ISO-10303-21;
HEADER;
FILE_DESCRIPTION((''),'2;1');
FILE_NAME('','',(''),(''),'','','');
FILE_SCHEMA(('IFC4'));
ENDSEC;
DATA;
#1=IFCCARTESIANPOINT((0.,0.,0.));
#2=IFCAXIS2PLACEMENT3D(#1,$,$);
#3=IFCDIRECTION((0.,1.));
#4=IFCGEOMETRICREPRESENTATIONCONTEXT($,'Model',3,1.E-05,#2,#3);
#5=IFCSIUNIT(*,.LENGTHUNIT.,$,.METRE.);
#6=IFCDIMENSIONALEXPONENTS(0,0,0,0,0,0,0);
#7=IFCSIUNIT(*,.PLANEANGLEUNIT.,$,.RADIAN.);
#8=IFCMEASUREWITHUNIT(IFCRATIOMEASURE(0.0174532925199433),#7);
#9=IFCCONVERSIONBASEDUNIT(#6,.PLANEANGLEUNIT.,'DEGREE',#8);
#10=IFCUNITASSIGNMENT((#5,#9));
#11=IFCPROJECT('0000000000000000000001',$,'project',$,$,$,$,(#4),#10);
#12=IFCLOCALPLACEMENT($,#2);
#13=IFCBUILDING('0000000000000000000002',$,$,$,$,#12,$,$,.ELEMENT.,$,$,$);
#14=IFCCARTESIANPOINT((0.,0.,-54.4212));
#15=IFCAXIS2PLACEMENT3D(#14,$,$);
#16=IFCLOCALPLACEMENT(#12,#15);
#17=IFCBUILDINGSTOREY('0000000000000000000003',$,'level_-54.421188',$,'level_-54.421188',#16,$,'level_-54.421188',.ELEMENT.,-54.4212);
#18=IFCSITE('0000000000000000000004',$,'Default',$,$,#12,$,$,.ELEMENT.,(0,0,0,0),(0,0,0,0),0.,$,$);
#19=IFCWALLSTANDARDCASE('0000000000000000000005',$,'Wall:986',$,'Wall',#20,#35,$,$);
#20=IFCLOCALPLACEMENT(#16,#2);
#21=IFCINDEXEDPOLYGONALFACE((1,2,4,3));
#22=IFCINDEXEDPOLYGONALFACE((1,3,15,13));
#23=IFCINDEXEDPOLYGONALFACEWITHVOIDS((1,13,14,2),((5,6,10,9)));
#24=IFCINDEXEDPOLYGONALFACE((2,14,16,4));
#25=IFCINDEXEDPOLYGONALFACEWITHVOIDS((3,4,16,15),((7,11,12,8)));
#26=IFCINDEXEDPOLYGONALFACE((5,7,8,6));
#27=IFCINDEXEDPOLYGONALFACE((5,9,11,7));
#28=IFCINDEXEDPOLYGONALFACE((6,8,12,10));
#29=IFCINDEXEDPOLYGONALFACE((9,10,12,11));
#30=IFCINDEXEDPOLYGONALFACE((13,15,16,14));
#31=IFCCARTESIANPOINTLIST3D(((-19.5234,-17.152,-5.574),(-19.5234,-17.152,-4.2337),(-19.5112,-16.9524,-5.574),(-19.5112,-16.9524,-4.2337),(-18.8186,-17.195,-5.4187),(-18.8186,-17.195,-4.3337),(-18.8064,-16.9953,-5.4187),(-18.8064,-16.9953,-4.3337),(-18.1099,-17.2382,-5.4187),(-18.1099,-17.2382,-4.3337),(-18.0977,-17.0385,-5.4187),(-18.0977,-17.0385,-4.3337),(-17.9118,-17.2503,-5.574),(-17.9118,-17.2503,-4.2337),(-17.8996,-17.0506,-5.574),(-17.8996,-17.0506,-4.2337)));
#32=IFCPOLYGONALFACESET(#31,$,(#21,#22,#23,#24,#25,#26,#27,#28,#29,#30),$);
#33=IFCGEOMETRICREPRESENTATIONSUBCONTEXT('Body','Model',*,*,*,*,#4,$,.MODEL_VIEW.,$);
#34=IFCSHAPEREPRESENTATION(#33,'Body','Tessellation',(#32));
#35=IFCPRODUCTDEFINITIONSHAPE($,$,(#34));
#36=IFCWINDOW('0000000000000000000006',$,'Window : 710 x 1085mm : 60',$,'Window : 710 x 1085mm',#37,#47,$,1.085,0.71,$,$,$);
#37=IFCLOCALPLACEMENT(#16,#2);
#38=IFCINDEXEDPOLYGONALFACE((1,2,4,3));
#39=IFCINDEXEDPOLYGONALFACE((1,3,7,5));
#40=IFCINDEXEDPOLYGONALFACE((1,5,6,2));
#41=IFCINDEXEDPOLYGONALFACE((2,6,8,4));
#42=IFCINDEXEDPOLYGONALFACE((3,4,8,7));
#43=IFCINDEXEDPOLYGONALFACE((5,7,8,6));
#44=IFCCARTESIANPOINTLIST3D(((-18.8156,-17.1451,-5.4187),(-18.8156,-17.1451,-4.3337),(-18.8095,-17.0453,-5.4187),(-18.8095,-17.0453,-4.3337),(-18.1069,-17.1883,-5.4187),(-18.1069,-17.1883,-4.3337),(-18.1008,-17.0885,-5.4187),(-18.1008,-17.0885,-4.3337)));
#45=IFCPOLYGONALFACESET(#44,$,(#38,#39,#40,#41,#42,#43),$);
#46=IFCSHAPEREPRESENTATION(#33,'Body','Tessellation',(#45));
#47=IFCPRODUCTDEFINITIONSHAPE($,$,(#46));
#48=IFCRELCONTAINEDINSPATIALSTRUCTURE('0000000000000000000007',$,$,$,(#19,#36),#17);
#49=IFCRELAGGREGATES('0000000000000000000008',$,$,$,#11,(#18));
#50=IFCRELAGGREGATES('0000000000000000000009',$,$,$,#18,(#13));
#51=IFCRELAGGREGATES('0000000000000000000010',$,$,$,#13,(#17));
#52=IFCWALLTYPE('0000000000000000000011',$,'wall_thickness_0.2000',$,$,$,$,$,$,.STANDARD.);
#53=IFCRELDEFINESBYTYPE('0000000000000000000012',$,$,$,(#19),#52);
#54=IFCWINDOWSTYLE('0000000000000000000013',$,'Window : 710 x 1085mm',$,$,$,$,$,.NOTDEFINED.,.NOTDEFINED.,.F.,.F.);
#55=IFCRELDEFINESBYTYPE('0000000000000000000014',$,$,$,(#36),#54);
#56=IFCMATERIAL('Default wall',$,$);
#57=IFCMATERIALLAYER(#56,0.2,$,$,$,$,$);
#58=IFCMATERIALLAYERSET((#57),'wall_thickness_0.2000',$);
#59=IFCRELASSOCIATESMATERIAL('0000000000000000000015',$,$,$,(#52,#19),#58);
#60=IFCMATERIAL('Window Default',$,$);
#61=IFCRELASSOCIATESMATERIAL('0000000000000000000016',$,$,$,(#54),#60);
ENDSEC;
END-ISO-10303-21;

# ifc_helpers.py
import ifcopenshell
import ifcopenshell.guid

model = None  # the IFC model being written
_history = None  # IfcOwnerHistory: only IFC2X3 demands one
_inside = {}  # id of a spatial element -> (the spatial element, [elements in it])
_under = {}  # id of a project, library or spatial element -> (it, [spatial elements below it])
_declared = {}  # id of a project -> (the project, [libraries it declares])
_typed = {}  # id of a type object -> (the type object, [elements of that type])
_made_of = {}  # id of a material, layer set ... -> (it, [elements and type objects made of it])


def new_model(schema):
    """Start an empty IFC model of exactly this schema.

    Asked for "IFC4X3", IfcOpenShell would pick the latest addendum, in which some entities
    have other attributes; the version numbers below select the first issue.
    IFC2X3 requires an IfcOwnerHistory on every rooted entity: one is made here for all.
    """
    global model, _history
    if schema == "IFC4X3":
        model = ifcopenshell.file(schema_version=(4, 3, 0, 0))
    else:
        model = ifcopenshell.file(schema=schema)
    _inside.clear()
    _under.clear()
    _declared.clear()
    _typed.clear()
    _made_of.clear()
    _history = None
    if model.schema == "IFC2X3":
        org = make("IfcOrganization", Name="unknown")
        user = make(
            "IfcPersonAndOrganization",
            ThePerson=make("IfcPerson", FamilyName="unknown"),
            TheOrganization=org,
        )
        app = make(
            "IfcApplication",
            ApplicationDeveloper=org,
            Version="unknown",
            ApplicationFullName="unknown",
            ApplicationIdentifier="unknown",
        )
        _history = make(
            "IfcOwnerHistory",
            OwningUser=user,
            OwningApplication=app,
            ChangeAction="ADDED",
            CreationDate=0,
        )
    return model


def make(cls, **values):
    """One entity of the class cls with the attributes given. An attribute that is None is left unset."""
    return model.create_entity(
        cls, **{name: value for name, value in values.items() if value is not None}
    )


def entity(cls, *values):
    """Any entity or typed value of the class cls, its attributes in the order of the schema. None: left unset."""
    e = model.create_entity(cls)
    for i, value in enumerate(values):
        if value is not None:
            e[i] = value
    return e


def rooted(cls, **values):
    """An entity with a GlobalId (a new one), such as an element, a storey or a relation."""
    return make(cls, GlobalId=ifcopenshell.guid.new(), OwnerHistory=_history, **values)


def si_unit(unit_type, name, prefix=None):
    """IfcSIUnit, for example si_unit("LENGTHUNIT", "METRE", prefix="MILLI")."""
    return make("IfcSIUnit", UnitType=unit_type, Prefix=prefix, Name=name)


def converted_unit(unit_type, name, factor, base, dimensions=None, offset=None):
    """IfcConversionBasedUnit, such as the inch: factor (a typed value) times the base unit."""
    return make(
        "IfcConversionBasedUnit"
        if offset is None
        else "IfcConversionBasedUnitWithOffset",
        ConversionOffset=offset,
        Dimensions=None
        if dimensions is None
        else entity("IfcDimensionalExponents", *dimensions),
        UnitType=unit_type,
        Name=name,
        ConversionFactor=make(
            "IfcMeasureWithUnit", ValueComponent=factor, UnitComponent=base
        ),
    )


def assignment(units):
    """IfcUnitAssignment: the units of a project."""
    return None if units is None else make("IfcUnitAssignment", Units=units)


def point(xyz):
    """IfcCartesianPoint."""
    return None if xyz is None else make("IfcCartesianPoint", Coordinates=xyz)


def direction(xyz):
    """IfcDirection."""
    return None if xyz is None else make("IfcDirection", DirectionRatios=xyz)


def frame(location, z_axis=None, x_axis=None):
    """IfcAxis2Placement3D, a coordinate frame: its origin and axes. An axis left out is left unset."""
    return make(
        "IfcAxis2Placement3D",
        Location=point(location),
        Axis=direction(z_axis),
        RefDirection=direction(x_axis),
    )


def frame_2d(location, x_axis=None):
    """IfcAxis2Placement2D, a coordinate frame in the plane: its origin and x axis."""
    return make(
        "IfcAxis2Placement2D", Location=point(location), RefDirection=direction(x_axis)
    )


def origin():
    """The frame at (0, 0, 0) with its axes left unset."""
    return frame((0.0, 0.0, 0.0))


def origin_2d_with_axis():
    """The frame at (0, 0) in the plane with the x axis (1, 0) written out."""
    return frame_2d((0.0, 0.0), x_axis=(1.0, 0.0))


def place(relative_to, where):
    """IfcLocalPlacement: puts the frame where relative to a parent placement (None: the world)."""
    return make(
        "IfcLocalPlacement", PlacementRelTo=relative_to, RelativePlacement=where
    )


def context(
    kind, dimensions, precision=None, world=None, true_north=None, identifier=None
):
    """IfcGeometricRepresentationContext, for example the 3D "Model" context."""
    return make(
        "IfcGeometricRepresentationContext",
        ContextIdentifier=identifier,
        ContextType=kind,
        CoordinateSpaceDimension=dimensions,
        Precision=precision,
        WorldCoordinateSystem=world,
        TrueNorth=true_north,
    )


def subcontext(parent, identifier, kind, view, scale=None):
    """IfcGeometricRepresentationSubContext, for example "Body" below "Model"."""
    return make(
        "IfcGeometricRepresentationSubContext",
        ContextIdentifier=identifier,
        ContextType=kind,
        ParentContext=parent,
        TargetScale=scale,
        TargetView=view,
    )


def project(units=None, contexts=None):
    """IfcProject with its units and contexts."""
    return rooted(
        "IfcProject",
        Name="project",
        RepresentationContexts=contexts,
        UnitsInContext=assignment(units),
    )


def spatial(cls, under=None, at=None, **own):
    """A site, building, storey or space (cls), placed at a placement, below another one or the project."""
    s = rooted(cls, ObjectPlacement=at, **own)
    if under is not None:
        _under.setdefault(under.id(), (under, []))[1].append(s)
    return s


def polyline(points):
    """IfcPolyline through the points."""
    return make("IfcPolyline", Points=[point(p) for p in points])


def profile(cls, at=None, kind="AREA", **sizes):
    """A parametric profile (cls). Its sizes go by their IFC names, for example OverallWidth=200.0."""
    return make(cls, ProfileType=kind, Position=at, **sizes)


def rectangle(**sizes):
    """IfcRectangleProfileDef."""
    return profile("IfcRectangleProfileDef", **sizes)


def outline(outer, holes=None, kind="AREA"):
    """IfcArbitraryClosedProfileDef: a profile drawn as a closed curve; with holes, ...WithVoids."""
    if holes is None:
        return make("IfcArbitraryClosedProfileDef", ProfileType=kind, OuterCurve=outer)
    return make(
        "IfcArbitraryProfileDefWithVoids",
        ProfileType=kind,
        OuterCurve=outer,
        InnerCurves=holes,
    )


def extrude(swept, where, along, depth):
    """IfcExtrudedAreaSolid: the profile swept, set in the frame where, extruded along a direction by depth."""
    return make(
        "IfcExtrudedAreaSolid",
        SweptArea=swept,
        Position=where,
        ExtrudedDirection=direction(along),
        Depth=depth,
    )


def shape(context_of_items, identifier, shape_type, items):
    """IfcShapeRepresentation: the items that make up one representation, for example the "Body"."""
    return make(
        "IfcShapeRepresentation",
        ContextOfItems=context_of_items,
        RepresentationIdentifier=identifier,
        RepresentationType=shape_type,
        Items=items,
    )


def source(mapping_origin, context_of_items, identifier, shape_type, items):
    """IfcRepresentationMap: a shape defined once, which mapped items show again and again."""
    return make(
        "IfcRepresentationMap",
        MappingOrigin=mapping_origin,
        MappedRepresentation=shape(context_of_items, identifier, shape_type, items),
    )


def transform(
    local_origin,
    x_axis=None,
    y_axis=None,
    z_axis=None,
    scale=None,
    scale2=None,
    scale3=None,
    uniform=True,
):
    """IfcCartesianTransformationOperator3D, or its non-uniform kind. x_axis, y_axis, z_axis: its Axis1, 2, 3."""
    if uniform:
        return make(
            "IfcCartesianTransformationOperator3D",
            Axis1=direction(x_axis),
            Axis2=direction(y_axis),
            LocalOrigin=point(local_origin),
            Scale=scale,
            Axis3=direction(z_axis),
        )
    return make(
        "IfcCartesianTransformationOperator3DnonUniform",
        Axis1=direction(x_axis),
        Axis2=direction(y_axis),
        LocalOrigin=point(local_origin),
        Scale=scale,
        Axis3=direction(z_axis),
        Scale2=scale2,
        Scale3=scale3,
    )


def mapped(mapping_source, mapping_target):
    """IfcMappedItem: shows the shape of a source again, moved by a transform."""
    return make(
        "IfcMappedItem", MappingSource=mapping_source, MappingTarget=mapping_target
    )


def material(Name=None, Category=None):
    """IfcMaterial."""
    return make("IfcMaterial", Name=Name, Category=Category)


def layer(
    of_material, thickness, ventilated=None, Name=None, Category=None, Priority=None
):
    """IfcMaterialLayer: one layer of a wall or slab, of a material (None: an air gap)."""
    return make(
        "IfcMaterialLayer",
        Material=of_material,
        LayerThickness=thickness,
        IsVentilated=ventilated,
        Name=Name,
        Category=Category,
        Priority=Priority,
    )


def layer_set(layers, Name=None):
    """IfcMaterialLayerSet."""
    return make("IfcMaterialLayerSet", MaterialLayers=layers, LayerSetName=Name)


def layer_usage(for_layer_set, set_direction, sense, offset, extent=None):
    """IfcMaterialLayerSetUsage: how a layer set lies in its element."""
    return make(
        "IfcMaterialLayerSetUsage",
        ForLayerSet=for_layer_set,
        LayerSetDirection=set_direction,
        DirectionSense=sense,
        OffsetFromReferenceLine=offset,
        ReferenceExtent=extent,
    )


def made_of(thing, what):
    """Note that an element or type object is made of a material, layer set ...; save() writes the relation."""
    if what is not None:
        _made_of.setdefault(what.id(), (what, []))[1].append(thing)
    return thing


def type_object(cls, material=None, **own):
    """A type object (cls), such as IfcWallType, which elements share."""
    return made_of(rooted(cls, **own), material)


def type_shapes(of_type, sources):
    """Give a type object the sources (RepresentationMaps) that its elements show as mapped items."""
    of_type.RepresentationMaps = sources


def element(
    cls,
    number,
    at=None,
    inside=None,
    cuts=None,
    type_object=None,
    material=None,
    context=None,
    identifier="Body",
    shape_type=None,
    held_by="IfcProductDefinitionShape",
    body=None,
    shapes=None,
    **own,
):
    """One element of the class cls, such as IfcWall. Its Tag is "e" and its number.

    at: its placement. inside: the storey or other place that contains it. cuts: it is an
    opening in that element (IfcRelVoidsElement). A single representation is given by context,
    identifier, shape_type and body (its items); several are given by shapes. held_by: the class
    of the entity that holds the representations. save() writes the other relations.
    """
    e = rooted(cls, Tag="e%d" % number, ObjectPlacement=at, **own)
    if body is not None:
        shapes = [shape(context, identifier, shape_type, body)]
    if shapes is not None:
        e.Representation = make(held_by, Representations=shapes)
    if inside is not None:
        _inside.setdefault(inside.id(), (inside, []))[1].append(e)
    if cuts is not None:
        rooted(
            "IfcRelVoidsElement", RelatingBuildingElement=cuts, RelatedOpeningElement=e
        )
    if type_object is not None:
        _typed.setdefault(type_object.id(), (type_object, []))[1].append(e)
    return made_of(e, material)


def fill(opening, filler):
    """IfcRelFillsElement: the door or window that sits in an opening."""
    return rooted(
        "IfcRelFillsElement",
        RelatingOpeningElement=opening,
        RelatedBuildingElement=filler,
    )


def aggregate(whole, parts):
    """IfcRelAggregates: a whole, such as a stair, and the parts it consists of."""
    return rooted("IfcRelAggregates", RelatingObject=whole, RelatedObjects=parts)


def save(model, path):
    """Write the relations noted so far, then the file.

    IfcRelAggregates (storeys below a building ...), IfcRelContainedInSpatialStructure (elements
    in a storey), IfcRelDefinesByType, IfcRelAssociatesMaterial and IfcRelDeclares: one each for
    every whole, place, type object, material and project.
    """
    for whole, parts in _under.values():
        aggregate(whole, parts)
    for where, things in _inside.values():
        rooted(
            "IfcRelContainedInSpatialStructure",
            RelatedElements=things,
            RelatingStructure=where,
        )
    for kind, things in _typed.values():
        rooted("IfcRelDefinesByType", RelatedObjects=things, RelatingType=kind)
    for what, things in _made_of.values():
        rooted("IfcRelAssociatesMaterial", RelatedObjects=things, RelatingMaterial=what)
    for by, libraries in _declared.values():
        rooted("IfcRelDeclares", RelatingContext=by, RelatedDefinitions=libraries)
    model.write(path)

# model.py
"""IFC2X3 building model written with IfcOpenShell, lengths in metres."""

from ifc_helpers import new_model, entity, si_unit, converted_unit, direction, frame, frame_2d, origin, origin_2d_with_axis, place, context, subcontext, project, spatial, polyline, rectangle, outline, extrude, source, transform, mapped, material, layer, layer_set, layer_usage, type_object, type_shapes, element, fill, save


model = new_model("IFC2X3")

# Units and contexts
model_context = context("Model", 3, precision=1e-05, world=origin(), true_north=direction((0.0, 1.0)))
body_context = subcontext(model_context, "Body", "Model", "MODEL_VIEW")
ifc_project = project(units=[si_unit("LENGTHUNIT", "METRE"), converted_unit("PLANEANGLEUNIT", "DEGREE", entity("IfcRatioMeasure", 0.0174532925199433), si_unit("PLANEANGLEUNIT", "RADIAN"), dimensions=[0, 0, 0, 0, 0, 0, 0])], contexts=[model_context])

# Site, building, storey
placement_1 = place(None, origin())
site = spatial("IfcSite", under=ifc_project, at=placement_1, Name="Default", CompositionType="ELEMENT", RefLatitude=(0, 0, 0, 0), RefLongitude=(0, 0, 0, 0), RefElevation=0.0)
building = spatial("IfcBuilding", under=site, at=placement_1, CompositionType="ELEMENT")
storey_placement = place(placement_1, frame((0.0, 0.0, -54.4212)))
storey = spatial("IfcBuildingStorey", under=building, at=storey_placement, Name="level_-54.421188", ObjectType="level_-54.421188", LongName="level_-54.421188", CompositionType="ELEMENT", Elevation=-54.4212)

# Wall, opening, window
ifc_material_1 = material(Name="Default wall")
ifc_layer = layer(ifc_material_1, 0.2)
ifc_layer_set = layer_set([ifc_layer], Name="wall_thickness_0.2000")
ifc_layer_usage = layer_usage(ifc_layer_set, "AXIS2", "POSITIVE", -0.1)
wall_type = type_object("IfcWallType", Name="wall_thickness_0.2000", PredefinedType="STANDARD", material=ifc_layer_set)
placement_2 = place(placement_1, frame((0.0, 0.0, -59.9952)))
wall_1_placement = place(placement_2, frame((-17.9057, -17.1504, 0.0), z_axis=(0.0, 0.0, 1.0), x_axis=(-0.998147, 0.060844, 0.0)))
wall_1 = element("IfcWallStandardCase", 1, at=wall_1_placement, inside=storey, type_object=wall_type, material=ifc_layer_usage, Name="Wall:986", ObjectType="Wall", context=body_context, shape_type="SweptSolid", body=[
    extrude(outline(polyline([(1.6146, -0.1), (1.6146, 0.1), (0.0, 0.1), (0.0, -0.1), (1.6146, -0.1)])), origin(), (0.0, 0.0, 1.0), 1.3402),
])
opening_1_placement = place(wall_1_placement, frame((0.1985, -0.1, 0.1553)))
opening_1 = element("IfcOpeningElement", 2, at=opening_1_placement, cuts=wall_1, ObjectType="Opening", context=body_context, shape_type="SweptSolid", body=[
    extrude(rectangle(XDim=0.71, YDim=1.085, at=frame_2d((0.5425, 0.355), x_axis=(0.0, 1.0))), frame((0.0, 0.0, 0.0), z_axis=(0.0, 1.0, 0.0), x_axis=(0.0, 0.0, 1.0)), (0.0, 0.0, 1.0), 0.2),
])
ifc_material_2 = material(Name="Window Default")
window_style_1 = type_object("IfcWindowStyle", Name="Window : 710 x 1085mm", ConstructionType="NOTDEFINED", OperationType="NOTDEFINED", ParameterTakesPrecedence=False, Sizeable=False, material=ifc_material_2)
shared_shape_1 = source(origin(), body_context, "Body", "SweptSolid", [
    extrude(rectangle(XDim=0.1, YDim=0.71, at=origin_2d_with_axis()), frame((0.355, 0.1, 0.0), z_axis=(0.0, 0.0, 1.0), x_axis=(0.0, 1.0, 0.0)), (0.0, 0.0, 1.0), 1.085),
])
type_shapes(window_style_1, [shared_shape_1])
window_1_placement = place(opening_1_placement, origin())
window_1 = element("IfcWindow", 3, at=window_1_placement, inside=storey, type_object=window_style_1, Name="Window : 710 x 1085mm : 60", ObjectType="Window : 710 x 1085mm", OverallHeight=1.085, OverallWidth=0.71, context=body_context, shape_type="MappedRepresentation", body=[
    mapped(shared_shape_1, transform((0.0, 0.0, 0.0), scale=1.0)),
])
fill(opening_1, window_1)

save(model, "model.ifc")
